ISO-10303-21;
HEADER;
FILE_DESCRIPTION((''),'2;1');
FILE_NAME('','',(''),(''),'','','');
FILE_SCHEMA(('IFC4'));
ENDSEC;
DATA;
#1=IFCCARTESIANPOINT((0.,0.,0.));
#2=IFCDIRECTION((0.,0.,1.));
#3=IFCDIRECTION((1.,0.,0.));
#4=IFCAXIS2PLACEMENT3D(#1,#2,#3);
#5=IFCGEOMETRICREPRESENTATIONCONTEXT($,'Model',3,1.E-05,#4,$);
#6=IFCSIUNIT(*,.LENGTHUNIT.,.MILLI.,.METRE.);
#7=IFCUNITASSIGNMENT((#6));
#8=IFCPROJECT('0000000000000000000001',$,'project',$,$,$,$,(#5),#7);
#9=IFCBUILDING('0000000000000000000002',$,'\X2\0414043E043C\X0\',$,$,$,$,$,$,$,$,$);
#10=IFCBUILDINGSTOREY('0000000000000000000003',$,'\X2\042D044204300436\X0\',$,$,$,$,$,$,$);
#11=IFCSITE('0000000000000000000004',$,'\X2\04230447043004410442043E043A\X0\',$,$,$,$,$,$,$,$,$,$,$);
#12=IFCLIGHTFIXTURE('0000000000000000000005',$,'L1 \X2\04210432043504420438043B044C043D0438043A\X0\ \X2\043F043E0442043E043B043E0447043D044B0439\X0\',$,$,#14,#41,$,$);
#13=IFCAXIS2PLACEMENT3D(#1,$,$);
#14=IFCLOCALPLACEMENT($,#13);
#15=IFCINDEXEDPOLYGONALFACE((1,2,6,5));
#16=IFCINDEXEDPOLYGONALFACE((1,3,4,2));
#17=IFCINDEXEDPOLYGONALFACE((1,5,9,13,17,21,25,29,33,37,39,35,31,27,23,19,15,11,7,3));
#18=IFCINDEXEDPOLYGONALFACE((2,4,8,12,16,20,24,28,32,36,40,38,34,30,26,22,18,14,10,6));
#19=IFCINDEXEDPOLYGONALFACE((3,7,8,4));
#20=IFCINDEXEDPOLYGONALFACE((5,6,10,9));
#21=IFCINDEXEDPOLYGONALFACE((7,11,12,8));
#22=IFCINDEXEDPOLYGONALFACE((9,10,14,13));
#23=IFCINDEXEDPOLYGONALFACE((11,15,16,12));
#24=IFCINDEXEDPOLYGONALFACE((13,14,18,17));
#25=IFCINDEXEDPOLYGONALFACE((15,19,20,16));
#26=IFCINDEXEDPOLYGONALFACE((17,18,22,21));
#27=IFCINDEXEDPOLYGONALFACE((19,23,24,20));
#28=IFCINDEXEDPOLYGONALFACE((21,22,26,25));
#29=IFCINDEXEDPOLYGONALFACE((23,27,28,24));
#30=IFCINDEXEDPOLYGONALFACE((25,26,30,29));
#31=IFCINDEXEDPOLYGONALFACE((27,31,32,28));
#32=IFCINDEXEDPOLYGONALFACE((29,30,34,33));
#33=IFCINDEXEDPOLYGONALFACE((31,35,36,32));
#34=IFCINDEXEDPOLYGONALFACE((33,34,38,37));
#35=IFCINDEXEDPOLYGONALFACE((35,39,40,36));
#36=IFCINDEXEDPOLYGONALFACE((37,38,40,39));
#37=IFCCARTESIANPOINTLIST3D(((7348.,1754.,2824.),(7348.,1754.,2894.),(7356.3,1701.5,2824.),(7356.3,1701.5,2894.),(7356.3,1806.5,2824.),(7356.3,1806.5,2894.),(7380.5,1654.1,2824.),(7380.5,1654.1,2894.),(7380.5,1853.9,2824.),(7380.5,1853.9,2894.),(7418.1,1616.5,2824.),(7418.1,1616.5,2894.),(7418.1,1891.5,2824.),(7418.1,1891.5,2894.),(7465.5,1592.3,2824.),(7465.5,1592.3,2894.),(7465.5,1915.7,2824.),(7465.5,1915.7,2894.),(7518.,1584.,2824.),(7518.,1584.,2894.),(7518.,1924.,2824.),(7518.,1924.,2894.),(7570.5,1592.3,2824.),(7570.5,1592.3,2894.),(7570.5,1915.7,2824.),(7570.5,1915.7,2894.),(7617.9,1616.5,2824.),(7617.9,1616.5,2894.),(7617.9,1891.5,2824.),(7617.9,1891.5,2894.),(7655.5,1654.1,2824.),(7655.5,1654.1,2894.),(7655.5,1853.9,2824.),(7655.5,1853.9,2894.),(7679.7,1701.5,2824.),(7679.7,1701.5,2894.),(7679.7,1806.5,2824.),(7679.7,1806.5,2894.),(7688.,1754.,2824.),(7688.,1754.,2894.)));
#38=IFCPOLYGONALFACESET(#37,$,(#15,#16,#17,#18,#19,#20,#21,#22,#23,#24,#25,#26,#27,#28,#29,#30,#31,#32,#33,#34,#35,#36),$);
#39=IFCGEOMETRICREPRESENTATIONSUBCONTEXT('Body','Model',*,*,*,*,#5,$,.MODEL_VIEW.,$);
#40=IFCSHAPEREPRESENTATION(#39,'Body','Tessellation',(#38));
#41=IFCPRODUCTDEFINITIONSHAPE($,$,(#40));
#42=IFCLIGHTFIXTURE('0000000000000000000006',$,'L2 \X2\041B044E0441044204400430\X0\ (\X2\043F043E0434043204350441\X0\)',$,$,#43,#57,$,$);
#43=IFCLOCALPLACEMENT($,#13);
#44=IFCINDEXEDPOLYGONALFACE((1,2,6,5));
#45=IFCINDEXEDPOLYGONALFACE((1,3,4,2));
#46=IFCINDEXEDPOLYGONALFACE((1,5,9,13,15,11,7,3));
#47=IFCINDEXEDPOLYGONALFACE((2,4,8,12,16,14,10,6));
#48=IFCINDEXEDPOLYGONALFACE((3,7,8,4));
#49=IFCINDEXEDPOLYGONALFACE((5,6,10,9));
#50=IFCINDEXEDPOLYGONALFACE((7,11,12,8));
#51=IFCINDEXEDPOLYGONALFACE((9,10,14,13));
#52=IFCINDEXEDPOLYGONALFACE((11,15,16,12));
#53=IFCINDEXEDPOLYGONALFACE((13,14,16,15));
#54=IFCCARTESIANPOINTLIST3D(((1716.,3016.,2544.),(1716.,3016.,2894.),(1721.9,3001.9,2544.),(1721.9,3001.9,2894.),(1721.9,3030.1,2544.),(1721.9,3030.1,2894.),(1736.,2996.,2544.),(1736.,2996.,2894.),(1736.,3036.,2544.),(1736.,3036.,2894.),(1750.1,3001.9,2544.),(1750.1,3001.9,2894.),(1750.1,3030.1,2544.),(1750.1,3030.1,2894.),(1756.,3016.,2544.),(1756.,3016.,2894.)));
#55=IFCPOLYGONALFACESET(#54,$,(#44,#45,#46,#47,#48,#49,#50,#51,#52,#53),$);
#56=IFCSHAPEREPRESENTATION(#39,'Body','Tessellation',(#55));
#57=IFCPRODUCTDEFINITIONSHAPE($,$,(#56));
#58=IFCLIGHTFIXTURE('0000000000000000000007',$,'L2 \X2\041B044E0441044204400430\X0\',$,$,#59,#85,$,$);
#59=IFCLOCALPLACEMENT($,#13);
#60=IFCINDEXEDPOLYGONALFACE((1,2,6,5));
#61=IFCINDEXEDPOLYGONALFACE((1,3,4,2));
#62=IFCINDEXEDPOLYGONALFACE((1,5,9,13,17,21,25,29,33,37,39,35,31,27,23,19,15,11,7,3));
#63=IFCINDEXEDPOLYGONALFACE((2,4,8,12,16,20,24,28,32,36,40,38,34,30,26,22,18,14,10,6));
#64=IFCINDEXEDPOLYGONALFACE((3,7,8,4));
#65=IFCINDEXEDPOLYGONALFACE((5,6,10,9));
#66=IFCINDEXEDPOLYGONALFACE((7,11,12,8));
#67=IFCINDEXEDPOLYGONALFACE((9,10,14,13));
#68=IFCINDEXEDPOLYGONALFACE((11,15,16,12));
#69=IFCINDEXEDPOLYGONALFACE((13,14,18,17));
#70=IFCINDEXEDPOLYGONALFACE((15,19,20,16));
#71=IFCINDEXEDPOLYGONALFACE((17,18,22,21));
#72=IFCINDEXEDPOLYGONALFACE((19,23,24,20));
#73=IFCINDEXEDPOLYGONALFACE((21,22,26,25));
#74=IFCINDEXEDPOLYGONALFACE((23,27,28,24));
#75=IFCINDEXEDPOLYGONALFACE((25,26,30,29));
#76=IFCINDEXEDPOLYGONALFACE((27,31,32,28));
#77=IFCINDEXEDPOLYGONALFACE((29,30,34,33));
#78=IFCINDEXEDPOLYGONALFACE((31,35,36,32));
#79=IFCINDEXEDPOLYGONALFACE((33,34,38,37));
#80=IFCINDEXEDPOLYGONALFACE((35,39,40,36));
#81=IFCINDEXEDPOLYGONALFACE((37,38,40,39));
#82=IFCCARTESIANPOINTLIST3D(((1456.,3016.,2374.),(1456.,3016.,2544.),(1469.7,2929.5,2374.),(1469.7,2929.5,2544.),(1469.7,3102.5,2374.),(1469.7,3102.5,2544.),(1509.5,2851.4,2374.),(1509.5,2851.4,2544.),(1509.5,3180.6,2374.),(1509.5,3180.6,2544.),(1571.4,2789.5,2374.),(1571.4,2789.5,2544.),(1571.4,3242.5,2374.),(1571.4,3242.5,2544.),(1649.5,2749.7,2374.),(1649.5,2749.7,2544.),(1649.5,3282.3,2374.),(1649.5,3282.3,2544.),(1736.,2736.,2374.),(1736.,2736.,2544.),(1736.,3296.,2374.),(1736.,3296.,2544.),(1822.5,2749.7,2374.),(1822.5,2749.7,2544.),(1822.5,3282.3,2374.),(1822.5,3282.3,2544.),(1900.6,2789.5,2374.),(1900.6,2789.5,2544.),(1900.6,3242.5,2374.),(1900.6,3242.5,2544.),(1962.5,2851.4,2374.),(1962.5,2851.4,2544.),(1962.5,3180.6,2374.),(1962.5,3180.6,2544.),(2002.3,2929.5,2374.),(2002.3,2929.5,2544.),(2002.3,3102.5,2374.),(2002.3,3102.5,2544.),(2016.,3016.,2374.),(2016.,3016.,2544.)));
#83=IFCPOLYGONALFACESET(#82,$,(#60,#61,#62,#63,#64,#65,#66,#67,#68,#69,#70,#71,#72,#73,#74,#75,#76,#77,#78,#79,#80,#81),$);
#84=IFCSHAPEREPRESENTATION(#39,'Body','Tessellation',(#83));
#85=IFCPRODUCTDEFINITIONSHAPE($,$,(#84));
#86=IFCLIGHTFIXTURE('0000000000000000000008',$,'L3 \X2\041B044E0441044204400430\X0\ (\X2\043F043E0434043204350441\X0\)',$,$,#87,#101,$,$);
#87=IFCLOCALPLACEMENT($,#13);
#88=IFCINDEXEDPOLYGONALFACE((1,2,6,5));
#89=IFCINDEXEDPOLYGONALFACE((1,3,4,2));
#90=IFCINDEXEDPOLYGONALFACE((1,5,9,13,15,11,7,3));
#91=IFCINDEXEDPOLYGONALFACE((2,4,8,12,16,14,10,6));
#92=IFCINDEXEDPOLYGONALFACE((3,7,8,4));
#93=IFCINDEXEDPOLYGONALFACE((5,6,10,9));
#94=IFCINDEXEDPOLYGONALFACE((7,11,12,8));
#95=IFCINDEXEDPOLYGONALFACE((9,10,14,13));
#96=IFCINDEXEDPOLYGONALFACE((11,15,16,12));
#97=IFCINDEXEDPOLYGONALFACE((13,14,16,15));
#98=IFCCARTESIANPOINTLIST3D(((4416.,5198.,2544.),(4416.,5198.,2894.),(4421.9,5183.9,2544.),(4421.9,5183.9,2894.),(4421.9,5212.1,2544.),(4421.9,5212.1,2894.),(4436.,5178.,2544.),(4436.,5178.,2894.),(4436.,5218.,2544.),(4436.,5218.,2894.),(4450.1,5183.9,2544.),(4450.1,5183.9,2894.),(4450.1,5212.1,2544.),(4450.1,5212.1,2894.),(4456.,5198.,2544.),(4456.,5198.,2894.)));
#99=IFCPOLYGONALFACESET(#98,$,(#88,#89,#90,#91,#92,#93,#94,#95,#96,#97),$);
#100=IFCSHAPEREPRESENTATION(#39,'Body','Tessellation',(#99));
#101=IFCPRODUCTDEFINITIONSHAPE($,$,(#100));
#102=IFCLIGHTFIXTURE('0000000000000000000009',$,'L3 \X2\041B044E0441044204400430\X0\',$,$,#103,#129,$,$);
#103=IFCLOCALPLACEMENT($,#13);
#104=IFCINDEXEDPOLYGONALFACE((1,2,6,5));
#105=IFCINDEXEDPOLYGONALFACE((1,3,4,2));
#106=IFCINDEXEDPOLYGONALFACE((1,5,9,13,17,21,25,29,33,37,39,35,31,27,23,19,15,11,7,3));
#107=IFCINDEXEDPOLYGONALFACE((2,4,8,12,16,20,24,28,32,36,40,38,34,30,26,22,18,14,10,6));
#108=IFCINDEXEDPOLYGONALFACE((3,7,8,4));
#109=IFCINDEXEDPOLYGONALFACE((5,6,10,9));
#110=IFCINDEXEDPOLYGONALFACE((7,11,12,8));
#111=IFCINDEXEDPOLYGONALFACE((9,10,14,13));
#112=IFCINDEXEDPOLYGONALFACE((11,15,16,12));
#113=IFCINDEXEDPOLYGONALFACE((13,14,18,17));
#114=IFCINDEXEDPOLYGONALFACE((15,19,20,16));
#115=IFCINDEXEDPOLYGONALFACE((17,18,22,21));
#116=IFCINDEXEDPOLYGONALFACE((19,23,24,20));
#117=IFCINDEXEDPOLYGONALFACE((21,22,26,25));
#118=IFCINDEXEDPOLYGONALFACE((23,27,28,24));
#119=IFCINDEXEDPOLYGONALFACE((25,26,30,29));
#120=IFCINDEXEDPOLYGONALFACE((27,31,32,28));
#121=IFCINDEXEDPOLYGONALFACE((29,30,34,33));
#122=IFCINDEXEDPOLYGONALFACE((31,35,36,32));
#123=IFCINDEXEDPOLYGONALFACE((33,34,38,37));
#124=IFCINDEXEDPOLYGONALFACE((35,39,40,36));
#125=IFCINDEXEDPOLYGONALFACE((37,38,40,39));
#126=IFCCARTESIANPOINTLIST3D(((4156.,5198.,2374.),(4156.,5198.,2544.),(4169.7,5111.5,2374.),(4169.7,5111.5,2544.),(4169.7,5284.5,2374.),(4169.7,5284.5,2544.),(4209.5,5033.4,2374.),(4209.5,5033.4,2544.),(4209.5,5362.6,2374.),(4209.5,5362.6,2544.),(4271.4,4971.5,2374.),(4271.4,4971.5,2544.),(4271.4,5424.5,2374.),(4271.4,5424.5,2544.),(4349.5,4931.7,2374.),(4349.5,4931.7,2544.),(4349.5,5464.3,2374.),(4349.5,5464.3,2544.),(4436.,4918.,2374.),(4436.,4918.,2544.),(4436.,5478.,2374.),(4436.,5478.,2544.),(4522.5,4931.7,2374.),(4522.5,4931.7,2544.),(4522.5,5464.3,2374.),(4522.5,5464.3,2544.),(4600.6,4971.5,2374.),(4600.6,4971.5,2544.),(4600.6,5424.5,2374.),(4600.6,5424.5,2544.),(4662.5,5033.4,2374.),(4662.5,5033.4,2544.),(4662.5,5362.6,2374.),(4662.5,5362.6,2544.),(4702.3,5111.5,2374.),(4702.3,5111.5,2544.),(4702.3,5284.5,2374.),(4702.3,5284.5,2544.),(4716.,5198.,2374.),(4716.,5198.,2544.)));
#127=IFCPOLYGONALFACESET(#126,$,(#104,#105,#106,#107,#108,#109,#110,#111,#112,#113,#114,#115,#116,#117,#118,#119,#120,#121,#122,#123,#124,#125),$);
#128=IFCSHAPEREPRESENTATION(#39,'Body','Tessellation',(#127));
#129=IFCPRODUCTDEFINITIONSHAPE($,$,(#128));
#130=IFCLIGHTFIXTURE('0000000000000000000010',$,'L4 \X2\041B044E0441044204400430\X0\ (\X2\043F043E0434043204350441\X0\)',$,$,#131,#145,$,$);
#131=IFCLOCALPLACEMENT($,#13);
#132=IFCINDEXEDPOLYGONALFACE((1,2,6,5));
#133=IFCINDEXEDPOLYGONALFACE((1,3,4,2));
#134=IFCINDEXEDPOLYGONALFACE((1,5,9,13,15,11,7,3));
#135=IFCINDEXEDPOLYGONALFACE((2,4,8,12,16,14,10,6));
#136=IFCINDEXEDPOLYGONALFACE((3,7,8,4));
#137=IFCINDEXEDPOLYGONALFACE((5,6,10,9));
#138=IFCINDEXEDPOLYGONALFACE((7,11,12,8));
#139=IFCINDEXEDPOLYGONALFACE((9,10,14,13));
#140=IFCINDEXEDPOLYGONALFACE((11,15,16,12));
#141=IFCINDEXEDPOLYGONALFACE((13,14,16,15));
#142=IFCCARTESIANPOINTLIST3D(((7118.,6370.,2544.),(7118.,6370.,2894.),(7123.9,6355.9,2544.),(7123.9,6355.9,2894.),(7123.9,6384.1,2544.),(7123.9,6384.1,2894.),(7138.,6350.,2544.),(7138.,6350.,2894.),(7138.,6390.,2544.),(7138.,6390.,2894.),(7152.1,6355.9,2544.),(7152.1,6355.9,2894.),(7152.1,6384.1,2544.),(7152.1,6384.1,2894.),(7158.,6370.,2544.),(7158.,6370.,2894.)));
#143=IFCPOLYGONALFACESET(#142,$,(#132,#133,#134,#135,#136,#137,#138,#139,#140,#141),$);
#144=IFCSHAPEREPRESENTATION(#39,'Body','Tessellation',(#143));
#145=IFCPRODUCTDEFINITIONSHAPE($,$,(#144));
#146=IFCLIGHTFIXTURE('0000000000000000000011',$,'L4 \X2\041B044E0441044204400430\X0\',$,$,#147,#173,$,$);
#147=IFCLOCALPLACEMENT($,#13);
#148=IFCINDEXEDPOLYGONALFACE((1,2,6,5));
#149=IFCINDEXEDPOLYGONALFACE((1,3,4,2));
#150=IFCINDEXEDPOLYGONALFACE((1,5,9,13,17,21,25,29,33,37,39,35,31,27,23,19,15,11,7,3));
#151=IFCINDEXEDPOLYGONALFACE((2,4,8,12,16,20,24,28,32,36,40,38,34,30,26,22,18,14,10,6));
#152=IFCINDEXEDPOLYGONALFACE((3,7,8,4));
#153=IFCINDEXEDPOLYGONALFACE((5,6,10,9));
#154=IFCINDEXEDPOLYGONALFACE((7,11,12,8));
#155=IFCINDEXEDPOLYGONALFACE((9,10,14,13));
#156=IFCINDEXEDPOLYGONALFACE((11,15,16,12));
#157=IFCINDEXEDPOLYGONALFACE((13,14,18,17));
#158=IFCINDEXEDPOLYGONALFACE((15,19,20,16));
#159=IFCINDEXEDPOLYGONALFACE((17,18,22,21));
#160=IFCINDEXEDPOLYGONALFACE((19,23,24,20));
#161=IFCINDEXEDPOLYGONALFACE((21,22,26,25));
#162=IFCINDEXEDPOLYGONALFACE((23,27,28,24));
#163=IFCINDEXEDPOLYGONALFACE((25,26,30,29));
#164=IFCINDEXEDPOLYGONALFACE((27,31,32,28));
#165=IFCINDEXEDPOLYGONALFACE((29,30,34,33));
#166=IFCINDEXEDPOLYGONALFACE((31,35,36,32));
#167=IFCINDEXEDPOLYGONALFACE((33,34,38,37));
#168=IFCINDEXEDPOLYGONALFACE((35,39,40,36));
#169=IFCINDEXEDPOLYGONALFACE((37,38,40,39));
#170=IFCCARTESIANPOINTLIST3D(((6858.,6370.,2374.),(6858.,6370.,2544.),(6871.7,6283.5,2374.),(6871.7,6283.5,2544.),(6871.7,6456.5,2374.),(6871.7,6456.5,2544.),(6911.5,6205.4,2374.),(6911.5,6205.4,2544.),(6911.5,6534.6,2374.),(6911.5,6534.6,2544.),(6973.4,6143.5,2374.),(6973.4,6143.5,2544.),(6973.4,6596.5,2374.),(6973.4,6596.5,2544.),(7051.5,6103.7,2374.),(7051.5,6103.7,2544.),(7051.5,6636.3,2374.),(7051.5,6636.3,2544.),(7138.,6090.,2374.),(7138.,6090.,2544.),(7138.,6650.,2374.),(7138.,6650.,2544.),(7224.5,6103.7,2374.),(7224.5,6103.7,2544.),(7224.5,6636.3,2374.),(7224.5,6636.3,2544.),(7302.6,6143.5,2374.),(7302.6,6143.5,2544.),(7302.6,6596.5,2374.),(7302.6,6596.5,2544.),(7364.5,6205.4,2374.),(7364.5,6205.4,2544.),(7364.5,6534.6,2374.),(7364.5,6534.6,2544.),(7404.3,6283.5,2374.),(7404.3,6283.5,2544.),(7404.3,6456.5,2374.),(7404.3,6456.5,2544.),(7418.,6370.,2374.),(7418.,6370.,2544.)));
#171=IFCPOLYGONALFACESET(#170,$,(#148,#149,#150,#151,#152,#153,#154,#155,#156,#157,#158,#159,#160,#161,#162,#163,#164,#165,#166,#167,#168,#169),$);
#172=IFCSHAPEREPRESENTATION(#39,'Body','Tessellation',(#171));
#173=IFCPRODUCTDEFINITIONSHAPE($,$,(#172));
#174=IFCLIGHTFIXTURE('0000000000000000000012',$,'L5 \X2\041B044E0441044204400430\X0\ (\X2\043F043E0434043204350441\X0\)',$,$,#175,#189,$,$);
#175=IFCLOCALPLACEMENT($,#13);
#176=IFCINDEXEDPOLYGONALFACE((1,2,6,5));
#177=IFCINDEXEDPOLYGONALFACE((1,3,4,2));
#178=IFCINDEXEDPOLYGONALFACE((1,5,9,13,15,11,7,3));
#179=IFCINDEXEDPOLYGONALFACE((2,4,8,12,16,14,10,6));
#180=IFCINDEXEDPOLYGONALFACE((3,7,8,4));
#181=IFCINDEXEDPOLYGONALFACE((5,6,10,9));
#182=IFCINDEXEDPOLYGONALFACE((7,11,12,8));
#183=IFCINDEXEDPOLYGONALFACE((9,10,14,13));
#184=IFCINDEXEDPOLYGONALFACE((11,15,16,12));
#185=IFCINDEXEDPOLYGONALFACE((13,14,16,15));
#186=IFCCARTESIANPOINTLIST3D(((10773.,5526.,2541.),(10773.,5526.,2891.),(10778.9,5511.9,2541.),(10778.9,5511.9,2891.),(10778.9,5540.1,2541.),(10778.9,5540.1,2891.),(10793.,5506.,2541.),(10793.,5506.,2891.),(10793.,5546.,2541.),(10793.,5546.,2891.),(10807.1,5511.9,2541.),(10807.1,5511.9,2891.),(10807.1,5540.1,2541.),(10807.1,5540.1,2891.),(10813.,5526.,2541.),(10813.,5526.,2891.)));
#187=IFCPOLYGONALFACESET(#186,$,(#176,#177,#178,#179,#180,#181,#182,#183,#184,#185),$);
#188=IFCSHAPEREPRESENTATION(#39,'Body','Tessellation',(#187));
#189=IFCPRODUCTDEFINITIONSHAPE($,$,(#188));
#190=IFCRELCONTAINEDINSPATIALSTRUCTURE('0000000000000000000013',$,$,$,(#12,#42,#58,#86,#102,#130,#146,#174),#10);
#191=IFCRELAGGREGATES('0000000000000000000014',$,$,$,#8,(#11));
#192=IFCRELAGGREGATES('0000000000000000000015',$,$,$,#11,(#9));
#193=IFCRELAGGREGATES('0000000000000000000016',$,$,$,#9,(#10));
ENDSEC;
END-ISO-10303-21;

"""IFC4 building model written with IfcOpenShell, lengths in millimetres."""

from ifc_helpers import new_model, si_unit, frame, origin, origin_with_axes, place, context, subcontext, project, spatial, polyline, outline, extrude, element, save


model = new_model("IFC4")

# Units and contexts
model_context = context("Model", 3, precision=1e-05, world=origin_with_axes())
body_context = subcontext(model_context, "Body", "Model", "MODEL_VIEW")
ifc_project = project(units=[si_unit("LENGTHUNIT", "METRE", prefix="MILLI")], contexts=[model_context])

# Site, building, storey
site = spatial("IfcSite", under=ifc_project, Name="Участок")
building = spatial("IfcBuilding", under=site, Name="Дом")
storey = spatial("IfcBuildingStorey", under=building, Name="Этаж")

# Light fixtures
light_fixture_1_placement = place(None, frame((0.0, 0.0, 2824.0), z_axis=(0.0, 0.0, 1.0), x_axis=(1.0, 0.0, 0.0)))
element("IfcLightFixture", 1, at=light_fixture_1_placement, inside=storey, Name="L1 Светильник потолочный", context=body_context, shape_type="SweptSolid", body=[
    extrude(outline(polyline([(7688.0, 1754.0), (7679.7, 1806.5), (7655.5, 1853.9), (7617.9, 1891.5), (7570.5, 1915.7), (7518.0, 1924.0), (7465.5, 1915.7), (7418.1, 1891.5), (7380.5, 1853.9), (7356.3, 1806.5), (7348.0, 1754.0), (7356.3, 1701.5), (7380.5, 1654.1), (7418.1, 1616.5), (7465.5, 1592.3), (7518.0, 1584.0), (7570.5, 1592.3), (7617.9, 1616.5), (7655.5, 1654.1), (7679.7, 1701.5), (7688.0, 1754.0)])), origin(), (0.0, 0.0, 1.0), 70.0),
])
light_fixture_2_placement = place(None, frame((0.0, 0.0, 2544.0), z_axis=(0.0, 0.0, 1.0), x_axis=(1.0, 0.0, 0.0)))
element("IfcLightFixture", 2, at=light_fixture_2_placement, inside=storey, Name="L2 Люстра (подвес)", context=body_context, shape_type="SweptSolid", body=[
    extrude(outline(polyline([(1756.0, 3016.0), (1750.1, 3030.1), (1736.0, 3036.0), (1721.9, 3030.1), (1716.0, 3016.0), (1721.9, 3001.9), (1736.0, 2996.0), (1750.1, 3001.9), (1756.0, 3016.0)])), origin(), (0.0, 0.0, 1.0), 350.0),
])
light_fixture_3_placement = place(None, frame((0.0, 0.0, 2374.0), z_axis=(0.0, 0.0, 1.0), x_axis=(1.0, 0.0, 0.0)))
element("IfcLightFixture", 3, at=light_fixture_3_placement, inside=storey, Name="L2 Люстра", context=body_context, shape_type="SweptSolid", body=[
    extrude(outline(polyline([(2016.0, 3016.0), (2002.3, 3102.5), (1962.5, 3180.6), (1900.6, 3242.5), (1822.5, 3282.3), (1736.0, 3296.0), (1649.5, 3282.3), (1571.4, 3242.5), (1509.5, 3180.6), (1469.7, 3102.5), (1456.0, 3016.0), (1469.7, 2929.5), (1509.5, 2851.4), (1571.4, 2789.5), (1649.5, 2749.7), (1736.0, 2736.0), (1822.5, 2749.7), (1900.6, 2789.5), (1962.5, 2851.4), (2002.3, 2929.5), (2016.0, 3016.0)])), origin(), (0.0, 0.0, 1.0), 170.0),
])
light_fixture_4_placement = place(None, frame((0.0, 0.0, 2544.0), z_axis=(0.0, 0.0, 1.0), x_axis=(1.0, 0.0, 0.0)))
element("IfcLightFixture", 4, at=light_fixture_4_placement, inside=storey, Name="L3 Люстра (подвес)", context=body_context, shape_type="SweptSolid", body=[
    extrude(outline(polyline([(4456.0, 5198.0), (4450.1, 5212.1), (4436.0, 5218.0), (4421.9, 5212.1), (4416.0, 5198.0), (4421.9, 5183.9), (4436.0, 5178.0), (4450.1, 5183.9), (4456.0, 5198.0)])), origin(), (0.0, 0.0, 1.0), 350.0),
])
light_fixture_5_placement = place(None, frame((0.0, 0.0, 2374.0), z_axis=(0.0, 0.0, 1.0), x_axis=(1.0, 0.0, 0.0)))
element("IfcLightFixture", 5, at=light_fixture_5_placement, inside=storey, Name="L3 Люстра", context=body_context, shape_type="SweptSolid", body=[
    extrude(outline(polyline([(4716.0, 5198.0), (4702.3, 5284.5), (4662.5, 5362.6), (4600.6, 5424.5), (4522.5, 5464.3), (4436.0, 5478.0), (4349.5, 5464.3), (4271.4, 5424.5), (4209.5, 5362.6), (4169.7, 5284.5), (4156.0, 5198.0), (4169.7, 5111.5), (4209.5, 5033.4), (4271.4, 4971.5), (4349.5, 4931.7), (4436.0, 4918.0), (4522.5, 4931.7), (4600.6, 4971.5), (4662.5, 5033.4), (4702.3, 5111.5), (4716.0, 5198.0)])), origin(), (0.0, 0.0, 1.0), 170.0),
])
light_fixture_6_placement = place(None, frame((0.0, 0.0, 2544.0), z_axis=(0.0, 0.0, 1.0), x_axis=(1.0, 0.0, 0.0)))
element("IfcLightFixture", 6, at=light_fixture_6_placement, inside=storey, Name="L4 Люстра (подвес)", context=body_context, shape_type="SweptSolid", body=[
    extrude(outline(polyline([(7158.0, 6370.0), (7152.1, 6384.1), (7138.0, 6390.0), (7123.9, 6384.1), (7118.0, 6370.0), (7123.9, 6355.9), (7138.0, 6350.0), (7152.1, 6355.9), (7158.0, 6370.0)])), origin(), (0.0, 0.0, 1.0), 350.0),
])
light_fixture_7_placement = place(None, frame((0.0, 0.0, 2374.0), z_axis=(0.0, 0.0, 1.0), x_axis=(1.0, 0.0, 0.0)))
element("IfcLightFixture", 7, at=light_fixture_7_placement, inside=storey, Name="L4 Люстра", context=body_context, shape_type="SweptSolid", body=[
    extrude(outline(polyline([(7418.0, 6370.0), (7404.3, 6456.5), (7364.5, 6534.6), (7302.6, 6596.5), (7224.5, 6636.3), (7138.0, 6650.0), (7051.5, 6636.3), (6973.4, 6596.5), (6911.5, 6534.6), (6871.7, 6456.5), (6858.0, 6370.0), (6871.7, 6283.5), (6911.5, 6205.4), (6973.4, 6143.5), (7051.5, 6103.7), (7138.0, 6090.0), (7224.5, 6103.7), (7302.6, 6143.5), (7364.5, 6205.4), (7404.3, 6283.5), (7418.0, 6370.0)])), origin(), (0.0, 0.0, 1.0), 170.0),
])
light_fixture_8_placement = place(None, frame((0.0, 0.0, 2541.0), z_axis=(0.0, 0.0, 1.0), x_axis=(1.0, 0.0, 0.0)))
element("IfcLightFixture", 8, at=light_fixture_8_placement, inside=storey, Name="L5 Люстра (подвес)", context=body_context, shape_type="SweptSolid", body=[
    extrude(outline(polyline([(10813.0, 5526.0), (10807.1, 5540.1), (10793.0, 5546.0), (10778.9, 5540.1), (10773.0, 5526.0), (10778.9, 5511.9), (10793.0, 5506.0), (10807.1, 5511.9), (10813.0, 5526.0)])), origin(), (0.0, 0.0, 1.0), 350.0),
])

save(model, "model.ifc")
